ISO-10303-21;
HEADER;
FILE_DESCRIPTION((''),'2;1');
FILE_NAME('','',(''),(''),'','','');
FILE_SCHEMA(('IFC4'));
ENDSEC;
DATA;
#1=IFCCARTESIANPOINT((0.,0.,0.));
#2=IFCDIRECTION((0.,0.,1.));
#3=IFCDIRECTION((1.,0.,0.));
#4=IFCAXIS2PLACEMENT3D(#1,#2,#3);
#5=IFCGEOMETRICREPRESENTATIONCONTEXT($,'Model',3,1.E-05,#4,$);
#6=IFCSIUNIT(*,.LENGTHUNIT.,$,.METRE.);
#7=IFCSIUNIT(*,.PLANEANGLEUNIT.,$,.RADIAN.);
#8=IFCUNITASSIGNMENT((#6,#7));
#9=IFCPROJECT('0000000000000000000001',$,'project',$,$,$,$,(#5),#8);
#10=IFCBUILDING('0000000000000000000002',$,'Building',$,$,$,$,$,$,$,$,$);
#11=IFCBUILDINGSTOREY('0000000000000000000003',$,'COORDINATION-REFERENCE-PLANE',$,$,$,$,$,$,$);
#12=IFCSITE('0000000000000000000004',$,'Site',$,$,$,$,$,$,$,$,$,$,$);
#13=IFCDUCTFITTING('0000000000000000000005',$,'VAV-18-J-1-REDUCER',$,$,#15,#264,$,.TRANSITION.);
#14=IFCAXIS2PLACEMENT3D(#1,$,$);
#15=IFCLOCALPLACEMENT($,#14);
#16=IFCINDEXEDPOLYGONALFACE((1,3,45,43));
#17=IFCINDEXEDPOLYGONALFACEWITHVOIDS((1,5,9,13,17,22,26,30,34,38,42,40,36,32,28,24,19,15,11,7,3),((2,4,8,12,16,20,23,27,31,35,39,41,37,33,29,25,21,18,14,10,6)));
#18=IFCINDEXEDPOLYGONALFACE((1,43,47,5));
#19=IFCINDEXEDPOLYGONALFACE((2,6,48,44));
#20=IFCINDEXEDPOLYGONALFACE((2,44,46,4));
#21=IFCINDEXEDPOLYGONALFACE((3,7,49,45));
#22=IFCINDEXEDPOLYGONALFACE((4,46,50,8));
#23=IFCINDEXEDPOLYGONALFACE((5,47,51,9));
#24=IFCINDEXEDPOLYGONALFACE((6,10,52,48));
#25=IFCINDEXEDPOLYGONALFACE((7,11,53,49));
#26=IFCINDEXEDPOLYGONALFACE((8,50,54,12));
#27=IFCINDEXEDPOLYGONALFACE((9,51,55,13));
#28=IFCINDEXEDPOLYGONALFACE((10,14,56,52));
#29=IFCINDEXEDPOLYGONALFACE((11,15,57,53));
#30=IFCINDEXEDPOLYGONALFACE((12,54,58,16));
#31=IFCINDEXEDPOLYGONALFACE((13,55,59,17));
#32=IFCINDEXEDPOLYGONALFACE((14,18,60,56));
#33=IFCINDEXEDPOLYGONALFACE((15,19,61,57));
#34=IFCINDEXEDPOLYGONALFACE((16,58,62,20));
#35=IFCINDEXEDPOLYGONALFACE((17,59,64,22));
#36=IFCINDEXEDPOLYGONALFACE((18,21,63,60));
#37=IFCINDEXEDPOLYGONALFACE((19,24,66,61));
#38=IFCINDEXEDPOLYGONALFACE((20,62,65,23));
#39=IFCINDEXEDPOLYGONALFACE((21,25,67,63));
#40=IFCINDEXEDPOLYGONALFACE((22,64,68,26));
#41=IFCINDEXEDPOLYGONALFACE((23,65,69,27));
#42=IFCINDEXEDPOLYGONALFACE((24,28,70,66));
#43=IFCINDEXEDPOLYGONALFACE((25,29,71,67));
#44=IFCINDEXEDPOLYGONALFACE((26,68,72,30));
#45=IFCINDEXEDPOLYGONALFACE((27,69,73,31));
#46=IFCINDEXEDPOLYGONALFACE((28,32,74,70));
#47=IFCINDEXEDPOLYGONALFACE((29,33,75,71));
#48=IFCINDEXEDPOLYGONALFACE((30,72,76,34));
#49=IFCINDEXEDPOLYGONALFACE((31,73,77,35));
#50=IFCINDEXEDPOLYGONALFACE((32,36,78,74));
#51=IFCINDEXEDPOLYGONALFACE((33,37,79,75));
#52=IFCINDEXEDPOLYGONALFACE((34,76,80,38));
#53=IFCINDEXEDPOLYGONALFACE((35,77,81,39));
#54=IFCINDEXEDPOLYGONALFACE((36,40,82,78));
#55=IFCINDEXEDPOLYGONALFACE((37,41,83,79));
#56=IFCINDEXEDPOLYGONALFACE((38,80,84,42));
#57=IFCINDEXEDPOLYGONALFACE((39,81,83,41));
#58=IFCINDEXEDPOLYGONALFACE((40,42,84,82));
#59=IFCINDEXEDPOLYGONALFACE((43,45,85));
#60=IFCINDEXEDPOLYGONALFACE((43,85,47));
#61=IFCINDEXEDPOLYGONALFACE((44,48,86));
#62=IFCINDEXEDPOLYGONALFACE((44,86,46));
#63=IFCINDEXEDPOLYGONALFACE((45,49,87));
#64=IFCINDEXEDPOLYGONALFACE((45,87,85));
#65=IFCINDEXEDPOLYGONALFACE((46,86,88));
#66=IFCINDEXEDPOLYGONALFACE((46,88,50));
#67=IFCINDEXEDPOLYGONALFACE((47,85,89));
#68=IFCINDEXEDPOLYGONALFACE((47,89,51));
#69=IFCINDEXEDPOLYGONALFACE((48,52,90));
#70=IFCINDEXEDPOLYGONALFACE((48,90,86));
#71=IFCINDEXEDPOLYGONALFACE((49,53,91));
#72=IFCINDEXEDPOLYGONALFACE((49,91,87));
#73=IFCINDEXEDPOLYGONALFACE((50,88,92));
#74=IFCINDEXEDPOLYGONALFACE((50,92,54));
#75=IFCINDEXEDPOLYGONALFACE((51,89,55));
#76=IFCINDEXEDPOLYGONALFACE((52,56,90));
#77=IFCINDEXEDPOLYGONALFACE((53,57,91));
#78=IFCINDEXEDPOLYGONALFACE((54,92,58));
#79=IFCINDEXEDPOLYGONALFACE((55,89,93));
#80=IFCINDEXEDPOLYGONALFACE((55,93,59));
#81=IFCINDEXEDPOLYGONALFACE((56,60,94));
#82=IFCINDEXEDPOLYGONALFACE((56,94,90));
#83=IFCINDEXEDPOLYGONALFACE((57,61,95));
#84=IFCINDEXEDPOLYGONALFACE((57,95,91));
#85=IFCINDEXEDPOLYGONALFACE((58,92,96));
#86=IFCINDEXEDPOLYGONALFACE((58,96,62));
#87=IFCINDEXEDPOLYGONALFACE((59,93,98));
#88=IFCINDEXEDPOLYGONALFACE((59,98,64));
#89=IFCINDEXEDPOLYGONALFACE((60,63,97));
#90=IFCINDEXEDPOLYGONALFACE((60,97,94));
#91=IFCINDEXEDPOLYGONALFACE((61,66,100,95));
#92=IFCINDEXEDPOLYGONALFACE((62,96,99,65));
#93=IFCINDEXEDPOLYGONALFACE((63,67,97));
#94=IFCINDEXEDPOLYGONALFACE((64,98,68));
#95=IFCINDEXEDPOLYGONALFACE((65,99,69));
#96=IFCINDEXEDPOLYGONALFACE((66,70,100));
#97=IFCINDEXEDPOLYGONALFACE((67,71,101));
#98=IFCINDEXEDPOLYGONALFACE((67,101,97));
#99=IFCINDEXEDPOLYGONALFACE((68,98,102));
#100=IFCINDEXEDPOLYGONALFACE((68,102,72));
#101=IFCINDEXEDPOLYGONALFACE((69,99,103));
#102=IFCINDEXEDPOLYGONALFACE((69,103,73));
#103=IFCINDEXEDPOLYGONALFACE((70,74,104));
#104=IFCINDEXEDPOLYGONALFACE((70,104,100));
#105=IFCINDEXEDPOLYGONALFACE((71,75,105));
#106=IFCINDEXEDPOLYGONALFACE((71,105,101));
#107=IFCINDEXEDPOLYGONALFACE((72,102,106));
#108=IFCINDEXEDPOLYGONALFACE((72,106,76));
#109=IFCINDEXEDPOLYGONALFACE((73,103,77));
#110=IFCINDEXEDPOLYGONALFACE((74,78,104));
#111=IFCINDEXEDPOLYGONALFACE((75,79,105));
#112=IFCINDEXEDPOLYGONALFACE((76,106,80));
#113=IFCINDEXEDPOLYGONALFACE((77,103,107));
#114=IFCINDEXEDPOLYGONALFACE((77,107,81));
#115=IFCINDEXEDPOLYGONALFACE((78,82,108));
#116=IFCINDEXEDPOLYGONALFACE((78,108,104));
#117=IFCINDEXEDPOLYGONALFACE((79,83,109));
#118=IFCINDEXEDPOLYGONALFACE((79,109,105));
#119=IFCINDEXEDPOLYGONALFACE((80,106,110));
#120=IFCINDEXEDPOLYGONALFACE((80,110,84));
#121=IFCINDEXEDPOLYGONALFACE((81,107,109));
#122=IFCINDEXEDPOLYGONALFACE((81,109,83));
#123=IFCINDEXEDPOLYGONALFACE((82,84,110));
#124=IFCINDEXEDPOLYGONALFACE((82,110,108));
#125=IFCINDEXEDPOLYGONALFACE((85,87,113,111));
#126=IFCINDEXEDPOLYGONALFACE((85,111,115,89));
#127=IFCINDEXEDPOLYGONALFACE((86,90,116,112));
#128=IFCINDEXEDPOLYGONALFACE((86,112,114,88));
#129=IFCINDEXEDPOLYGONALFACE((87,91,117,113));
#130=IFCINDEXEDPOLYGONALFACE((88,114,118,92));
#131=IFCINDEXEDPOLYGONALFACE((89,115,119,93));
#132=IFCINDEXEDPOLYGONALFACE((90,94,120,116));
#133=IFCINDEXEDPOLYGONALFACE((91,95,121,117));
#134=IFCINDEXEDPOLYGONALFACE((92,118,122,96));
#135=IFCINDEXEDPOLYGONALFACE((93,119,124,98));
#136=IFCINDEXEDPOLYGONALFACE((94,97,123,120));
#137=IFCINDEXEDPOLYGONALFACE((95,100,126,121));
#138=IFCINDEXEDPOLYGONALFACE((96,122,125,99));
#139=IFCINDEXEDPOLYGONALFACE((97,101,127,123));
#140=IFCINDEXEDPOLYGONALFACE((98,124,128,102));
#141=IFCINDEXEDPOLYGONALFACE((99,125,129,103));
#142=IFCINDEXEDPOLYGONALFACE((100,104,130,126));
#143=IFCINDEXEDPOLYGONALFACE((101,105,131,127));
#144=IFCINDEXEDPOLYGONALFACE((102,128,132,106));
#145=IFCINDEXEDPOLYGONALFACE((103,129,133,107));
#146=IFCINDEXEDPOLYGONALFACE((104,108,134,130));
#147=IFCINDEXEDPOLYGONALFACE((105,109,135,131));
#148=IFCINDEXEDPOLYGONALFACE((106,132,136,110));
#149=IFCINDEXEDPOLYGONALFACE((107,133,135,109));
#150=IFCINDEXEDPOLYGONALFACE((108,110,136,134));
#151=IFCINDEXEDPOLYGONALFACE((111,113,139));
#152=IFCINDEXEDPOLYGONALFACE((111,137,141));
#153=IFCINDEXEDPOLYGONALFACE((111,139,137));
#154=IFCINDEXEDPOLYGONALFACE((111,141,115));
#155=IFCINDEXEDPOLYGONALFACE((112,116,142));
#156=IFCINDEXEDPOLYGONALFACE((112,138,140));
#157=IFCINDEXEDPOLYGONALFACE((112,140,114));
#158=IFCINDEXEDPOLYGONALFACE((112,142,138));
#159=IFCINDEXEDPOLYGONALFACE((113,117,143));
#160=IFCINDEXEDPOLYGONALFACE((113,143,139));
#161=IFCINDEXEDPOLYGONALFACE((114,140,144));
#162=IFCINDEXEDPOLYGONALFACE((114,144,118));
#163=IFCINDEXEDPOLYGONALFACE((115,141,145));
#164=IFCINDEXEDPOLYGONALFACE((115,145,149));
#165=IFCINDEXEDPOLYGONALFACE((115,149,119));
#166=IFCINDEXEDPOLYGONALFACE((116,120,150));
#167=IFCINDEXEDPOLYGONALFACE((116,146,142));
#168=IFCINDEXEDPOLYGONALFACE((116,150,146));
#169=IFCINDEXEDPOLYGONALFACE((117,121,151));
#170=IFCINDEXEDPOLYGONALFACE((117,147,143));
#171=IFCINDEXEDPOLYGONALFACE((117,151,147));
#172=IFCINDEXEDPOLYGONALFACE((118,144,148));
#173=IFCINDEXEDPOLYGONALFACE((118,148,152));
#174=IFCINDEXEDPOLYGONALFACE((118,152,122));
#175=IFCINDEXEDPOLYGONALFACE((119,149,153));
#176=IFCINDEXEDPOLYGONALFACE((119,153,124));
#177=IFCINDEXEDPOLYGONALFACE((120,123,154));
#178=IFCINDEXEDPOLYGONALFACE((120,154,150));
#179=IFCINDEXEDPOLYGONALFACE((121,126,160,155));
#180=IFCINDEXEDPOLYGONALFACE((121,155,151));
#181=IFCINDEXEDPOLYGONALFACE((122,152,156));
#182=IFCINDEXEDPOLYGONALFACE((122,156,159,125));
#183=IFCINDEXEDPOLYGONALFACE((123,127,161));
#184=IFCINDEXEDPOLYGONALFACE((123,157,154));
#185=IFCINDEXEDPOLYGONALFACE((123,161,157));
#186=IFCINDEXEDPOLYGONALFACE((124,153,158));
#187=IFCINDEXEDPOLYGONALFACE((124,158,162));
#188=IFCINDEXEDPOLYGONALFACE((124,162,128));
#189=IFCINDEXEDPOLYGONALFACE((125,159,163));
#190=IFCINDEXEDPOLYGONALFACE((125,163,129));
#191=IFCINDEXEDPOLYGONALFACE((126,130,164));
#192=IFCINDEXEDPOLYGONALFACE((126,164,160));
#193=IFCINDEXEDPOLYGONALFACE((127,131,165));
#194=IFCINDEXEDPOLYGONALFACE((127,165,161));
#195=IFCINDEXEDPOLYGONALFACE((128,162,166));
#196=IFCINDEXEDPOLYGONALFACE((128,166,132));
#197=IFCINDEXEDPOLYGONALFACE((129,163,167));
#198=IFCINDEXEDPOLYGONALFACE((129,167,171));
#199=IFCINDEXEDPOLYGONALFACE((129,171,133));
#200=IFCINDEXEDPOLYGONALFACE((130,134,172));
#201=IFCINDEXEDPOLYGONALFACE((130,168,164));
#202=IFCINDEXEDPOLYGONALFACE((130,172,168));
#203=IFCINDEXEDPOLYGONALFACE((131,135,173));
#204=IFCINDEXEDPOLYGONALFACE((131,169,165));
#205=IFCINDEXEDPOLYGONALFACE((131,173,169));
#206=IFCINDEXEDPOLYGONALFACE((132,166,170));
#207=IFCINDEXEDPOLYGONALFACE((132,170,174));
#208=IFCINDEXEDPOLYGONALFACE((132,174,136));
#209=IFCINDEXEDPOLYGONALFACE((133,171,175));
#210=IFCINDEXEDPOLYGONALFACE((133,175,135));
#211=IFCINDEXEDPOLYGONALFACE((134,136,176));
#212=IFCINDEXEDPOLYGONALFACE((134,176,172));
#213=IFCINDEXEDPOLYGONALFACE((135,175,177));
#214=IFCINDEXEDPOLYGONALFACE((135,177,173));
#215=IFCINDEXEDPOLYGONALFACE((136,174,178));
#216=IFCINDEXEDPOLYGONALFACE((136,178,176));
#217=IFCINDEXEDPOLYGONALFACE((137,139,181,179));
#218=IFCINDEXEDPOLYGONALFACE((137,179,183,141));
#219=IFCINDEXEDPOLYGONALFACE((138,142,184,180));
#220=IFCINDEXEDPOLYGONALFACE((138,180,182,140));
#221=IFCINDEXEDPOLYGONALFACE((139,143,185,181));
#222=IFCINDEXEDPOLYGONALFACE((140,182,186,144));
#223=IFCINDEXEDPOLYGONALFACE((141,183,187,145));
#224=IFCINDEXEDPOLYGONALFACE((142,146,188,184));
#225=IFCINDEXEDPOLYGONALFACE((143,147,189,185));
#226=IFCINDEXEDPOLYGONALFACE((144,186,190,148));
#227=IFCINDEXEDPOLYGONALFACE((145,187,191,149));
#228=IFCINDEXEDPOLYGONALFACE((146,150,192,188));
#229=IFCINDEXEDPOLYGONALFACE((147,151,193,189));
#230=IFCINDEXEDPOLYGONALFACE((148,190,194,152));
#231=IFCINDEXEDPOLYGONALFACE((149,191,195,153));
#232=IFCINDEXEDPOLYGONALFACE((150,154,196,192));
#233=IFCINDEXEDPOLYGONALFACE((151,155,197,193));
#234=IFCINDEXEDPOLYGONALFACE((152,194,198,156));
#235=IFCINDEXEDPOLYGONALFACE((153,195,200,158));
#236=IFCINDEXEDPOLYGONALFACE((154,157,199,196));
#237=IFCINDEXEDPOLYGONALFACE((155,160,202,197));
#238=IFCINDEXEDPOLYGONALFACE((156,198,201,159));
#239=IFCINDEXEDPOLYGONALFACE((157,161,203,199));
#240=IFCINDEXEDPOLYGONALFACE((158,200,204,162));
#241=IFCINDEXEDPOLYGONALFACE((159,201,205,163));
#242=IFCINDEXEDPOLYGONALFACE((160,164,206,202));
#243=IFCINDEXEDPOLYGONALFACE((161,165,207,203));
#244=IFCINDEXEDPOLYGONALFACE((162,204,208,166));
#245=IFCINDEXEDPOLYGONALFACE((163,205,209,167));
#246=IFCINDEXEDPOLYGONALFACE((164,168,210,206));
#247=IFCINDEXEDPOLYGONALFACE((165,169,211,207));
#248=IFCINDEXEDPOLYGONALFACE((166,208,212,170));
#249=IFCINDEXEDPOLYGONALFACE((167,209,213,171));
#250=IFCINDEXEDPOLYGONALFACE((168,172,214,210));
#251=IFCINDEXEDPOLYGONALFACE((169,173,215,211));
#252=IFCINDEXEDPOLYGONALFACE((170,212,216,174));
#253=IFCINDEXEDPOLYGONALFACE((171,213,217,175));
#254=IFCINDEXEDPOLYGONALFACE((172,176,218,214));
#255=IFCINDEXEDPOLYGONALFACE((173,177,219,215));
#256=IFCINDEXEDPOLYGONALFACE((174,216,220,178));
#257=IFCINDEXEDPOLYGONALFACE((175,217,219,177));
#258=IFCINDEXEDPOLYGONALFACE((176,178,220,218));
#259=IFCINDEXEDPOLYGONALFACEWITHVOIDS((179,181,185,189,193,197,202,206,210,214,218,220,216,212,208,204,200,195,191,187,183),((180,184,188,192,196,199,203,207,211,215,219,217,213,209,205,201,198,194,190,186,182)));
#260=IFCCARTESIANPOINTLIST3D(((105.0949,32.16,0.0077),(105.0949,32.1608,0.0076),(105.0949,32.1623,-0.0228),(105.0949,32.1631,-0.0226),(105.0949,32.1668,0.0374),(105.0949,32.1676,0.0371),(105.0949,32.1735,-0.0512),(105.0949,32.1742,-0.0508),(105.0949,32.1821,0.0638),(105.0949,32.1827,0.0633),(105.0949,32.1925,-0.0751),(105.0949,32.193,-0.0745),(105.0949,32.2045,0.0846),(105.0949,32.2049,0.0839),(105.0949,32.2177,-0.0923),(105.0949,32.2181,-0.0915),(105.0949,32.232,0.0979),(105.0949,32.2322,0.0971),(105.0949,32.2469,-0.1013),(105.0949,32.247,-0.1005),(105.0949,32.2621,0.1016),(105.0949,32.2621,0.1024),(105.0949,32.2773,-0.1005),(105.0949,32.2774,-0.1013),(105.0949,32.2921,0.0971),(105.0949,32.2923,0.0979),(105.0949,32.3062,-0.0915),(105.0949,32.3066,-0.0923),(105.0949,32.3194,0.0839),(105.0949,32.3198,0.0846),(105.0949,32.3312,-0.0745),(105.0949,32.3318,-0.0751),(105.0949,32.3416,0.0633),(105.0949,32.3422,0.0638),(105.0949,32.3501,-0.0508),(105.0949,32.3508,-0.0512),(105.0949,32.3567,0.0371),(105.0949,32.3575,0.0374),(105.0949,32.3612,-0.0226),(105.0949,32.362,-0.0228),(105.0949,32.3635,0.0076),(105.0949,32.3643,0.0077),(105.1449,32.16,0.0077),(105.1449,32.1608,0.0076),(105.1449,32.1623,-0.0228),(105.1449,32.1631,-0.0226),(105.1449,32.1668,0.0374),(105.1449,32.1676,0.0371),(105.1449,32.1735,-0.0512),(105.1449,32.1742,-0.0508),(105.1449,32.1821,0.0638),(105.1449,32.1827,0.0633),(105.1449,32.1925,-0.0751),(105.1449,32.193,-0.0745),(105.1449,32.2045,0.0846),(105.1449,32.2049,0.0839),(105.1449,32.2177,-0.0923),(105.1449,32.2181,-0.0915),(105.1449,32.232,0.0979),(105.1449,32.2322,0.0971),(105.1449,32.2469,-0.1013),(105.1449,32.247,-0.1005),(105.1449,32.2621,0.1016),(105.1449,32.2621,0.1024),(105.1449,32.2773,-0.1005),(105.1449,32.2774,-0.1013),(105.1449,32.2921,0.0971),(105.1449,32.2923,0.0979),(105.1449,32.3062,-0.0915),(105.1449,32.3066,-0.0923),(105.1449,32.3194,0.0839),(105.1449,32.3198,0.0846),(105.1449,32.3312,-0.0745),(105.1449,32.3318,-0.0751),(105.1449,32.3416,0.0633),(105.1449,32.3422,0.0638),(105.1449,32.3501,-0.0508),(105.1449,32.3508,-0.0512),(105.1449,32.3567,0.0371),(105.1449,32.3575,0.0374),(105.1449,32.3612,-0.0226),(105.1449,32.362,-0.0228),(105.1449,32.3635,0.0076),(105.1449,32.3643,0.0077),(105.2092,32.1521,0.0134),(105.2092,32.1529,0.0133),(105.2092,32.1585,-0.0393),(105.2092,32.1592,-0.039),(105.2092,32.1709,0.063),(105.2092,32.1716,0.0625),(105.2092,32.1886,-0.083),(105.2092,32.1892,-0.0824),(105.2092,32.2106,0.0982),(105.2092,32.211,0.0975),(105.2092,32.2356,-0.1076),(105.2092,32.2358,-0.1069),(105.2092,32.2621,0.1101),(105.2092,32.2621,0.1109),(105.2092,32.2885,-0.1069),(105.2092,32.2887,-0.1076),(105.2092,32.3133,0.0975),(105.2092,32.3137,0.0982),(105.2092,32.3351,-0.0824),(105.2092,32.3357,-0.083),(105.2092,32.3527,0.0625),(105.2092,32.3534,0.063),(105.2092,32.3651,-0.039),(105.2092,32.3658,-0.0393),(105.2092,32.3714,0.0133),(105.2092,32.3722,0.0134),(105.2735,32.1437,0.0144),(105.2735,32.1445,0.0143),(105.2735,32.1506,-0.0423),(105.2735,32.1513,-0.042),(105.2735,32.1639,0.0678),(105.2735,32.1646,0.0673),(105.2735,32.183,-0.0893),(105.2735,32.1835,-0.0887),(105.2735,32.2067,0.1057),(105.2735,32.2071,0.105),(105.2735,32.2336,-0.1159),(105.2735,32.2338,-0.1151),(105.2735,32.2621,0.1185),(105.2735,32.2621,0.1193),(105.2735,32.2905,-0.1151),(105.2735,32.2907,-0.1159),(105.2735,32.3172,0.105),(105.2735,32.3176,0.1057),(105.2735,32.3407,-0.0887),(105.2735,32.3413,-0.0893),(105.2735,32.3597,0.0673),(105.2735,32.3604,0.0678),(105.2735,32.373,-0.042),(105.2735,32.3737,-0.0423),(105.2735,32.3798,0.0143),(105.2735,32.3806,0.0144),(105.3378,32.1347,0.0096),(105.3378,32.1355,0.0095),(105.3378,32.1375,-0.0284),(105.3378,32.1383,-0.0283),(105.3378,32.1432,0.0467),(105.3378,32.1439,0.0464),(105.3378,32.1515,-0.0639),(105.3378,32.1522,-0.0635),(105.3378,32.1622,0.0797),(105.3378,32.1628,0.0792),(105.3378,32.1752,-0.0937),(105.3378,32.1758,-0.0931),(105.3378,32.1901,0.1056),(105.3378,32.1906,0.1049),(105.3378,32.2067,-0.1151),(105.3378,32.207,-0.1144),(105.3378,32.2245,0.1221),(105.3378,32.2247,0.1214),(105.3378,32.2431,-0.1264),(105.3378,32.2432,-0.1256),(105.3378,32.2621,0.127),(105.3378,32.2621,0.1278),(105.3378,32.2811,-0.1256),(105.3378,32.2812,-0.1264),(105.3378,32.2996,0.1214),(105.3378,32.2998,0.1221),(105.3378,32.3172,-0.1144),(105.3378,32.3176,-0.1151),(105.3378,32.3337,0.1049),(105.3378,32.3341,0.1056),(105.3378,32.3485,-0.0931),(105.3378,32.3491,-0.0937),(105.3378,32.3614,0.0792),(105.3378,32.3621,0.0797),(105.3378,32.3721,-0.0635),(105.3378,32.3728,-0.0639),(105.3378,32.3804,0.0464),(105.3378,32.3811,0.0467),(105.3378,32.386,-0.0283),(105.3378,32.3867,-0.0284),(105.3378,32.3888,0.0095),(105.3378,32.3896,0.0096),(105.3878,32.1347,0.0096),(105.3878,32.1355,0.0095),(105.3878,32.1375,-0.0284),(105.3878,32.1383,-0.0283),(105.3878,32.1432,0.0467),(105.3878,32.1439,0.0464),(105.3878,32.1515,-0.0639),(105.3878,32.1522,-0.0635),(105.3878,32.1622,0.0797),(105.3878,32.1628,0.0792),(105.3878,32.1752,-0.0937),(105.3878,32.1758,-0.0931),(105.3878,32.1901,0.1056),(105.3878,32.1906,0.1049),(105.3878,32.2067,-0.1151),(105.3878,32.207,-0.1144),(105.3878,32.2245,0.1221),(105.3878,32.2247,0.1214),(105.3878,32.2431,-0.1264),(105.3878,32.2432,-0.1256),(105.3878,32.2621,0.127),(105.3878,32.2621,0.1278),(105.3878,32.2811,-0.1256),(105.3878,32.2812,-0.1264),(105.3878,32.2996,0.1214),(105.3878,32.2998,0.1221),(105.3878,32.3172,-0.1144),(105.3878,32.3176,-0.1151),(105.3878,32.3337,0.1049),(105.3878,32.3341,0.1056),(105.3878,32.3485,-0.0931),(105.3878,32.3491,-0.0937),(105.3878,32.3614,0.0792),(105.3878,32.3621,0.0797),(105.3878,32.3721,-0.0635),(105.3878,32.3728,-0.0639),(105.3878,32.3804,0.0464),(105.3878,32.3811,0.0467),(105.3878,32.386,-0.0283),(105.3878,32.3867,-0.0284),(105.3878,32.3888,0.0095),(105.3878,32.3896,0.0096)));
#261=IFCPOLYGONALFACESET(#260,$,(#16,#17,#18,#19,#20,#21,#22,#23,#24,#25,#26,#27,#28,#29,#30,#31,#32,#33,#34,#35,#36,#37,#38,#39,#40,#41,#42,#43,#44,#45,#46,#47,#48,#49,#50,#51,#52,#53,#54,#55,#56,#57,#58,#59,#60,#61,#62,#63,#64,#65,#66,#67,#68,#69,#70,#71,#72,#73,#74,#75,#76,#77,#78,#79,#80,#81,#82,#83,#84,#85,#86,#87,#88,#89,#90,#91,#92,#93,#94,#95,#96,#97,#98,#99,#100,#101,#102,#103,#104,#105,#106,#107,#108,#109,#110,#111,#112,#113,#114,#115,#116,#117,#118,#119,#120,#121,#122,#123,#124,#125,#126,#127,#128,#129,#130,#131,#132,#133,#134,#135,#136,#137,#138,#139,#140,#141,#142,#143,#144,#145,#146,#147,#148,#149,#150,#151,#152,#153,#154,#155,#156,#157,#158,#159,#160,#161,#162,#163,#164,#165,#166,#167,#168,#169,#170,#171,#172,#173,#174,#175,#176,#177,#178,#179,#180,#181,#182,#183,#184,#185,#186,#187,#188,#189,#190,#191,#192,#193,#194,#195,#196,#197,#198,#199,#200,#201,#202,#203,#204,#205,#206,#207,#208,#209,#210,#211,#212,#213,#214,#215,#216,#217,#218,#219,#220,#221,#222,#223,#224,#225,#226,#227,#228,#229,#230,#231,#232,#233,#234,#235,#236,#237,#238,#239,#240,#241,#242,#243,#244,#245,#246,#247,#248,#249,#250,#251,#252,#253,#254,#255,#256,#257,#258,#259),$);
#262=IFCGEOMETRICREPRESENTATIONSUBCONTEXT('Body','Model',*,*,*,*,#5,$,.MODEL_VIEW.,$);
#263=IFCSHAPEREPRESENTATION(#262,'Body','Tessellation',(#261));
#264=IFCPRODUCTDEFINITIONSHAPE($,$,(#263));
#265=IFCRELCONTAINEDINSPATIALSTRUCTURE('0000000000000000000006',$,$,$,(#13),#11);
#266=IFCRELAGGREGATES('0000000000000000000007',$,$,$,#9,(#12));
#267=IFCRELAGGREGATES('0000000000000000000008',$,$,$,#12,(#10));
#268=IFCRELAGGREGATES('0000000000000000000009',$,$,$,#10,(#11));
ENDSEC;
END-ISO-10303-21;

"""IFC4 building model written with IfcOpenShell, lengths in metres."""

from ifc_helpers import new_model, entity, si_unit, frame, origin_with_axes, place, context, subcontext, project, spatial, element, save


model = new_model("IFC4")

# Units and contexts
model_context = context("Model", 3, precision=1e-05, world=origin_with_axes())
body_context_1 = subcontext(model_context, "Body", "Model", "MODEL_VIEW")
ifc_project = project(units=[si_unit("LENGTHUNIT", "METRE"), si_unit("PLANEANGLEUNIT", "RADIAN")], contexts=[model_context])

# Site, building, storey
site = spatial("IfcSite", under=ifc_project, Name="Site")
building = spatial("IfcBuilding", under=site, Name="Building")
storey = spatial("IfcBuildingStorey", under=building, Name="COORDINATION-REFERENCE-PLANE")

# Duct fitting
for number, where, z_axis, x_axis, name in (
    (1, (105.3878, 32.2621, 0.0), (0.0, -1.0, 0.0), (0.0, 0.0, 1.0), "VAV-18-J-1-REDUCER"),
):
    element("IfcDuctFitting", number, at=place(None, frame(where, z_axis=z_axis, x_axis=x_axis)), inside=storey, Name=name, PredefinedType="TRANSITION", context=body_context_1, shape_type="SweptSolid", body=[
        entity("IfcRevolvedAreaSolid", entity("IfcArbitraryClosedProfileDef", "AREA", None, entity("IfcPolyline", [entity("IfcCartesianPoint", [0.1278, 0.0]), entity("IfcCartesianPoint", [0.1278, 0.05]), entity("IfcCartesianPoint", [0.1024, 0.2429]), entity("IfcCartesianPoint", [0.1024, 0.2929]), entity("IfcCartesianPoint", [0.1016, 0.2929]), entity("IfcCartesianPoint", [0.1016, 0.2429]), entity("IfcCartesianPoint", [0.127, 0.05]), entity("IfcCartesianPoint", [0.127, 0.0]), entity("IfcCartesianPoint", [0.1278, 0.0])])), entity("IfcAxis2Placement3D", entity("IfcCartesianPoint", [0.0, 0.0, 0.0])), entity("IfcAxis1Placement", entity("IfcCartesianPoint", [0.0, 0.0, 0.0]), entity("IfcDirection", [0.0, 1.0, 0.0])), 6.283185),
    ])

save(model, "model.ifc")
